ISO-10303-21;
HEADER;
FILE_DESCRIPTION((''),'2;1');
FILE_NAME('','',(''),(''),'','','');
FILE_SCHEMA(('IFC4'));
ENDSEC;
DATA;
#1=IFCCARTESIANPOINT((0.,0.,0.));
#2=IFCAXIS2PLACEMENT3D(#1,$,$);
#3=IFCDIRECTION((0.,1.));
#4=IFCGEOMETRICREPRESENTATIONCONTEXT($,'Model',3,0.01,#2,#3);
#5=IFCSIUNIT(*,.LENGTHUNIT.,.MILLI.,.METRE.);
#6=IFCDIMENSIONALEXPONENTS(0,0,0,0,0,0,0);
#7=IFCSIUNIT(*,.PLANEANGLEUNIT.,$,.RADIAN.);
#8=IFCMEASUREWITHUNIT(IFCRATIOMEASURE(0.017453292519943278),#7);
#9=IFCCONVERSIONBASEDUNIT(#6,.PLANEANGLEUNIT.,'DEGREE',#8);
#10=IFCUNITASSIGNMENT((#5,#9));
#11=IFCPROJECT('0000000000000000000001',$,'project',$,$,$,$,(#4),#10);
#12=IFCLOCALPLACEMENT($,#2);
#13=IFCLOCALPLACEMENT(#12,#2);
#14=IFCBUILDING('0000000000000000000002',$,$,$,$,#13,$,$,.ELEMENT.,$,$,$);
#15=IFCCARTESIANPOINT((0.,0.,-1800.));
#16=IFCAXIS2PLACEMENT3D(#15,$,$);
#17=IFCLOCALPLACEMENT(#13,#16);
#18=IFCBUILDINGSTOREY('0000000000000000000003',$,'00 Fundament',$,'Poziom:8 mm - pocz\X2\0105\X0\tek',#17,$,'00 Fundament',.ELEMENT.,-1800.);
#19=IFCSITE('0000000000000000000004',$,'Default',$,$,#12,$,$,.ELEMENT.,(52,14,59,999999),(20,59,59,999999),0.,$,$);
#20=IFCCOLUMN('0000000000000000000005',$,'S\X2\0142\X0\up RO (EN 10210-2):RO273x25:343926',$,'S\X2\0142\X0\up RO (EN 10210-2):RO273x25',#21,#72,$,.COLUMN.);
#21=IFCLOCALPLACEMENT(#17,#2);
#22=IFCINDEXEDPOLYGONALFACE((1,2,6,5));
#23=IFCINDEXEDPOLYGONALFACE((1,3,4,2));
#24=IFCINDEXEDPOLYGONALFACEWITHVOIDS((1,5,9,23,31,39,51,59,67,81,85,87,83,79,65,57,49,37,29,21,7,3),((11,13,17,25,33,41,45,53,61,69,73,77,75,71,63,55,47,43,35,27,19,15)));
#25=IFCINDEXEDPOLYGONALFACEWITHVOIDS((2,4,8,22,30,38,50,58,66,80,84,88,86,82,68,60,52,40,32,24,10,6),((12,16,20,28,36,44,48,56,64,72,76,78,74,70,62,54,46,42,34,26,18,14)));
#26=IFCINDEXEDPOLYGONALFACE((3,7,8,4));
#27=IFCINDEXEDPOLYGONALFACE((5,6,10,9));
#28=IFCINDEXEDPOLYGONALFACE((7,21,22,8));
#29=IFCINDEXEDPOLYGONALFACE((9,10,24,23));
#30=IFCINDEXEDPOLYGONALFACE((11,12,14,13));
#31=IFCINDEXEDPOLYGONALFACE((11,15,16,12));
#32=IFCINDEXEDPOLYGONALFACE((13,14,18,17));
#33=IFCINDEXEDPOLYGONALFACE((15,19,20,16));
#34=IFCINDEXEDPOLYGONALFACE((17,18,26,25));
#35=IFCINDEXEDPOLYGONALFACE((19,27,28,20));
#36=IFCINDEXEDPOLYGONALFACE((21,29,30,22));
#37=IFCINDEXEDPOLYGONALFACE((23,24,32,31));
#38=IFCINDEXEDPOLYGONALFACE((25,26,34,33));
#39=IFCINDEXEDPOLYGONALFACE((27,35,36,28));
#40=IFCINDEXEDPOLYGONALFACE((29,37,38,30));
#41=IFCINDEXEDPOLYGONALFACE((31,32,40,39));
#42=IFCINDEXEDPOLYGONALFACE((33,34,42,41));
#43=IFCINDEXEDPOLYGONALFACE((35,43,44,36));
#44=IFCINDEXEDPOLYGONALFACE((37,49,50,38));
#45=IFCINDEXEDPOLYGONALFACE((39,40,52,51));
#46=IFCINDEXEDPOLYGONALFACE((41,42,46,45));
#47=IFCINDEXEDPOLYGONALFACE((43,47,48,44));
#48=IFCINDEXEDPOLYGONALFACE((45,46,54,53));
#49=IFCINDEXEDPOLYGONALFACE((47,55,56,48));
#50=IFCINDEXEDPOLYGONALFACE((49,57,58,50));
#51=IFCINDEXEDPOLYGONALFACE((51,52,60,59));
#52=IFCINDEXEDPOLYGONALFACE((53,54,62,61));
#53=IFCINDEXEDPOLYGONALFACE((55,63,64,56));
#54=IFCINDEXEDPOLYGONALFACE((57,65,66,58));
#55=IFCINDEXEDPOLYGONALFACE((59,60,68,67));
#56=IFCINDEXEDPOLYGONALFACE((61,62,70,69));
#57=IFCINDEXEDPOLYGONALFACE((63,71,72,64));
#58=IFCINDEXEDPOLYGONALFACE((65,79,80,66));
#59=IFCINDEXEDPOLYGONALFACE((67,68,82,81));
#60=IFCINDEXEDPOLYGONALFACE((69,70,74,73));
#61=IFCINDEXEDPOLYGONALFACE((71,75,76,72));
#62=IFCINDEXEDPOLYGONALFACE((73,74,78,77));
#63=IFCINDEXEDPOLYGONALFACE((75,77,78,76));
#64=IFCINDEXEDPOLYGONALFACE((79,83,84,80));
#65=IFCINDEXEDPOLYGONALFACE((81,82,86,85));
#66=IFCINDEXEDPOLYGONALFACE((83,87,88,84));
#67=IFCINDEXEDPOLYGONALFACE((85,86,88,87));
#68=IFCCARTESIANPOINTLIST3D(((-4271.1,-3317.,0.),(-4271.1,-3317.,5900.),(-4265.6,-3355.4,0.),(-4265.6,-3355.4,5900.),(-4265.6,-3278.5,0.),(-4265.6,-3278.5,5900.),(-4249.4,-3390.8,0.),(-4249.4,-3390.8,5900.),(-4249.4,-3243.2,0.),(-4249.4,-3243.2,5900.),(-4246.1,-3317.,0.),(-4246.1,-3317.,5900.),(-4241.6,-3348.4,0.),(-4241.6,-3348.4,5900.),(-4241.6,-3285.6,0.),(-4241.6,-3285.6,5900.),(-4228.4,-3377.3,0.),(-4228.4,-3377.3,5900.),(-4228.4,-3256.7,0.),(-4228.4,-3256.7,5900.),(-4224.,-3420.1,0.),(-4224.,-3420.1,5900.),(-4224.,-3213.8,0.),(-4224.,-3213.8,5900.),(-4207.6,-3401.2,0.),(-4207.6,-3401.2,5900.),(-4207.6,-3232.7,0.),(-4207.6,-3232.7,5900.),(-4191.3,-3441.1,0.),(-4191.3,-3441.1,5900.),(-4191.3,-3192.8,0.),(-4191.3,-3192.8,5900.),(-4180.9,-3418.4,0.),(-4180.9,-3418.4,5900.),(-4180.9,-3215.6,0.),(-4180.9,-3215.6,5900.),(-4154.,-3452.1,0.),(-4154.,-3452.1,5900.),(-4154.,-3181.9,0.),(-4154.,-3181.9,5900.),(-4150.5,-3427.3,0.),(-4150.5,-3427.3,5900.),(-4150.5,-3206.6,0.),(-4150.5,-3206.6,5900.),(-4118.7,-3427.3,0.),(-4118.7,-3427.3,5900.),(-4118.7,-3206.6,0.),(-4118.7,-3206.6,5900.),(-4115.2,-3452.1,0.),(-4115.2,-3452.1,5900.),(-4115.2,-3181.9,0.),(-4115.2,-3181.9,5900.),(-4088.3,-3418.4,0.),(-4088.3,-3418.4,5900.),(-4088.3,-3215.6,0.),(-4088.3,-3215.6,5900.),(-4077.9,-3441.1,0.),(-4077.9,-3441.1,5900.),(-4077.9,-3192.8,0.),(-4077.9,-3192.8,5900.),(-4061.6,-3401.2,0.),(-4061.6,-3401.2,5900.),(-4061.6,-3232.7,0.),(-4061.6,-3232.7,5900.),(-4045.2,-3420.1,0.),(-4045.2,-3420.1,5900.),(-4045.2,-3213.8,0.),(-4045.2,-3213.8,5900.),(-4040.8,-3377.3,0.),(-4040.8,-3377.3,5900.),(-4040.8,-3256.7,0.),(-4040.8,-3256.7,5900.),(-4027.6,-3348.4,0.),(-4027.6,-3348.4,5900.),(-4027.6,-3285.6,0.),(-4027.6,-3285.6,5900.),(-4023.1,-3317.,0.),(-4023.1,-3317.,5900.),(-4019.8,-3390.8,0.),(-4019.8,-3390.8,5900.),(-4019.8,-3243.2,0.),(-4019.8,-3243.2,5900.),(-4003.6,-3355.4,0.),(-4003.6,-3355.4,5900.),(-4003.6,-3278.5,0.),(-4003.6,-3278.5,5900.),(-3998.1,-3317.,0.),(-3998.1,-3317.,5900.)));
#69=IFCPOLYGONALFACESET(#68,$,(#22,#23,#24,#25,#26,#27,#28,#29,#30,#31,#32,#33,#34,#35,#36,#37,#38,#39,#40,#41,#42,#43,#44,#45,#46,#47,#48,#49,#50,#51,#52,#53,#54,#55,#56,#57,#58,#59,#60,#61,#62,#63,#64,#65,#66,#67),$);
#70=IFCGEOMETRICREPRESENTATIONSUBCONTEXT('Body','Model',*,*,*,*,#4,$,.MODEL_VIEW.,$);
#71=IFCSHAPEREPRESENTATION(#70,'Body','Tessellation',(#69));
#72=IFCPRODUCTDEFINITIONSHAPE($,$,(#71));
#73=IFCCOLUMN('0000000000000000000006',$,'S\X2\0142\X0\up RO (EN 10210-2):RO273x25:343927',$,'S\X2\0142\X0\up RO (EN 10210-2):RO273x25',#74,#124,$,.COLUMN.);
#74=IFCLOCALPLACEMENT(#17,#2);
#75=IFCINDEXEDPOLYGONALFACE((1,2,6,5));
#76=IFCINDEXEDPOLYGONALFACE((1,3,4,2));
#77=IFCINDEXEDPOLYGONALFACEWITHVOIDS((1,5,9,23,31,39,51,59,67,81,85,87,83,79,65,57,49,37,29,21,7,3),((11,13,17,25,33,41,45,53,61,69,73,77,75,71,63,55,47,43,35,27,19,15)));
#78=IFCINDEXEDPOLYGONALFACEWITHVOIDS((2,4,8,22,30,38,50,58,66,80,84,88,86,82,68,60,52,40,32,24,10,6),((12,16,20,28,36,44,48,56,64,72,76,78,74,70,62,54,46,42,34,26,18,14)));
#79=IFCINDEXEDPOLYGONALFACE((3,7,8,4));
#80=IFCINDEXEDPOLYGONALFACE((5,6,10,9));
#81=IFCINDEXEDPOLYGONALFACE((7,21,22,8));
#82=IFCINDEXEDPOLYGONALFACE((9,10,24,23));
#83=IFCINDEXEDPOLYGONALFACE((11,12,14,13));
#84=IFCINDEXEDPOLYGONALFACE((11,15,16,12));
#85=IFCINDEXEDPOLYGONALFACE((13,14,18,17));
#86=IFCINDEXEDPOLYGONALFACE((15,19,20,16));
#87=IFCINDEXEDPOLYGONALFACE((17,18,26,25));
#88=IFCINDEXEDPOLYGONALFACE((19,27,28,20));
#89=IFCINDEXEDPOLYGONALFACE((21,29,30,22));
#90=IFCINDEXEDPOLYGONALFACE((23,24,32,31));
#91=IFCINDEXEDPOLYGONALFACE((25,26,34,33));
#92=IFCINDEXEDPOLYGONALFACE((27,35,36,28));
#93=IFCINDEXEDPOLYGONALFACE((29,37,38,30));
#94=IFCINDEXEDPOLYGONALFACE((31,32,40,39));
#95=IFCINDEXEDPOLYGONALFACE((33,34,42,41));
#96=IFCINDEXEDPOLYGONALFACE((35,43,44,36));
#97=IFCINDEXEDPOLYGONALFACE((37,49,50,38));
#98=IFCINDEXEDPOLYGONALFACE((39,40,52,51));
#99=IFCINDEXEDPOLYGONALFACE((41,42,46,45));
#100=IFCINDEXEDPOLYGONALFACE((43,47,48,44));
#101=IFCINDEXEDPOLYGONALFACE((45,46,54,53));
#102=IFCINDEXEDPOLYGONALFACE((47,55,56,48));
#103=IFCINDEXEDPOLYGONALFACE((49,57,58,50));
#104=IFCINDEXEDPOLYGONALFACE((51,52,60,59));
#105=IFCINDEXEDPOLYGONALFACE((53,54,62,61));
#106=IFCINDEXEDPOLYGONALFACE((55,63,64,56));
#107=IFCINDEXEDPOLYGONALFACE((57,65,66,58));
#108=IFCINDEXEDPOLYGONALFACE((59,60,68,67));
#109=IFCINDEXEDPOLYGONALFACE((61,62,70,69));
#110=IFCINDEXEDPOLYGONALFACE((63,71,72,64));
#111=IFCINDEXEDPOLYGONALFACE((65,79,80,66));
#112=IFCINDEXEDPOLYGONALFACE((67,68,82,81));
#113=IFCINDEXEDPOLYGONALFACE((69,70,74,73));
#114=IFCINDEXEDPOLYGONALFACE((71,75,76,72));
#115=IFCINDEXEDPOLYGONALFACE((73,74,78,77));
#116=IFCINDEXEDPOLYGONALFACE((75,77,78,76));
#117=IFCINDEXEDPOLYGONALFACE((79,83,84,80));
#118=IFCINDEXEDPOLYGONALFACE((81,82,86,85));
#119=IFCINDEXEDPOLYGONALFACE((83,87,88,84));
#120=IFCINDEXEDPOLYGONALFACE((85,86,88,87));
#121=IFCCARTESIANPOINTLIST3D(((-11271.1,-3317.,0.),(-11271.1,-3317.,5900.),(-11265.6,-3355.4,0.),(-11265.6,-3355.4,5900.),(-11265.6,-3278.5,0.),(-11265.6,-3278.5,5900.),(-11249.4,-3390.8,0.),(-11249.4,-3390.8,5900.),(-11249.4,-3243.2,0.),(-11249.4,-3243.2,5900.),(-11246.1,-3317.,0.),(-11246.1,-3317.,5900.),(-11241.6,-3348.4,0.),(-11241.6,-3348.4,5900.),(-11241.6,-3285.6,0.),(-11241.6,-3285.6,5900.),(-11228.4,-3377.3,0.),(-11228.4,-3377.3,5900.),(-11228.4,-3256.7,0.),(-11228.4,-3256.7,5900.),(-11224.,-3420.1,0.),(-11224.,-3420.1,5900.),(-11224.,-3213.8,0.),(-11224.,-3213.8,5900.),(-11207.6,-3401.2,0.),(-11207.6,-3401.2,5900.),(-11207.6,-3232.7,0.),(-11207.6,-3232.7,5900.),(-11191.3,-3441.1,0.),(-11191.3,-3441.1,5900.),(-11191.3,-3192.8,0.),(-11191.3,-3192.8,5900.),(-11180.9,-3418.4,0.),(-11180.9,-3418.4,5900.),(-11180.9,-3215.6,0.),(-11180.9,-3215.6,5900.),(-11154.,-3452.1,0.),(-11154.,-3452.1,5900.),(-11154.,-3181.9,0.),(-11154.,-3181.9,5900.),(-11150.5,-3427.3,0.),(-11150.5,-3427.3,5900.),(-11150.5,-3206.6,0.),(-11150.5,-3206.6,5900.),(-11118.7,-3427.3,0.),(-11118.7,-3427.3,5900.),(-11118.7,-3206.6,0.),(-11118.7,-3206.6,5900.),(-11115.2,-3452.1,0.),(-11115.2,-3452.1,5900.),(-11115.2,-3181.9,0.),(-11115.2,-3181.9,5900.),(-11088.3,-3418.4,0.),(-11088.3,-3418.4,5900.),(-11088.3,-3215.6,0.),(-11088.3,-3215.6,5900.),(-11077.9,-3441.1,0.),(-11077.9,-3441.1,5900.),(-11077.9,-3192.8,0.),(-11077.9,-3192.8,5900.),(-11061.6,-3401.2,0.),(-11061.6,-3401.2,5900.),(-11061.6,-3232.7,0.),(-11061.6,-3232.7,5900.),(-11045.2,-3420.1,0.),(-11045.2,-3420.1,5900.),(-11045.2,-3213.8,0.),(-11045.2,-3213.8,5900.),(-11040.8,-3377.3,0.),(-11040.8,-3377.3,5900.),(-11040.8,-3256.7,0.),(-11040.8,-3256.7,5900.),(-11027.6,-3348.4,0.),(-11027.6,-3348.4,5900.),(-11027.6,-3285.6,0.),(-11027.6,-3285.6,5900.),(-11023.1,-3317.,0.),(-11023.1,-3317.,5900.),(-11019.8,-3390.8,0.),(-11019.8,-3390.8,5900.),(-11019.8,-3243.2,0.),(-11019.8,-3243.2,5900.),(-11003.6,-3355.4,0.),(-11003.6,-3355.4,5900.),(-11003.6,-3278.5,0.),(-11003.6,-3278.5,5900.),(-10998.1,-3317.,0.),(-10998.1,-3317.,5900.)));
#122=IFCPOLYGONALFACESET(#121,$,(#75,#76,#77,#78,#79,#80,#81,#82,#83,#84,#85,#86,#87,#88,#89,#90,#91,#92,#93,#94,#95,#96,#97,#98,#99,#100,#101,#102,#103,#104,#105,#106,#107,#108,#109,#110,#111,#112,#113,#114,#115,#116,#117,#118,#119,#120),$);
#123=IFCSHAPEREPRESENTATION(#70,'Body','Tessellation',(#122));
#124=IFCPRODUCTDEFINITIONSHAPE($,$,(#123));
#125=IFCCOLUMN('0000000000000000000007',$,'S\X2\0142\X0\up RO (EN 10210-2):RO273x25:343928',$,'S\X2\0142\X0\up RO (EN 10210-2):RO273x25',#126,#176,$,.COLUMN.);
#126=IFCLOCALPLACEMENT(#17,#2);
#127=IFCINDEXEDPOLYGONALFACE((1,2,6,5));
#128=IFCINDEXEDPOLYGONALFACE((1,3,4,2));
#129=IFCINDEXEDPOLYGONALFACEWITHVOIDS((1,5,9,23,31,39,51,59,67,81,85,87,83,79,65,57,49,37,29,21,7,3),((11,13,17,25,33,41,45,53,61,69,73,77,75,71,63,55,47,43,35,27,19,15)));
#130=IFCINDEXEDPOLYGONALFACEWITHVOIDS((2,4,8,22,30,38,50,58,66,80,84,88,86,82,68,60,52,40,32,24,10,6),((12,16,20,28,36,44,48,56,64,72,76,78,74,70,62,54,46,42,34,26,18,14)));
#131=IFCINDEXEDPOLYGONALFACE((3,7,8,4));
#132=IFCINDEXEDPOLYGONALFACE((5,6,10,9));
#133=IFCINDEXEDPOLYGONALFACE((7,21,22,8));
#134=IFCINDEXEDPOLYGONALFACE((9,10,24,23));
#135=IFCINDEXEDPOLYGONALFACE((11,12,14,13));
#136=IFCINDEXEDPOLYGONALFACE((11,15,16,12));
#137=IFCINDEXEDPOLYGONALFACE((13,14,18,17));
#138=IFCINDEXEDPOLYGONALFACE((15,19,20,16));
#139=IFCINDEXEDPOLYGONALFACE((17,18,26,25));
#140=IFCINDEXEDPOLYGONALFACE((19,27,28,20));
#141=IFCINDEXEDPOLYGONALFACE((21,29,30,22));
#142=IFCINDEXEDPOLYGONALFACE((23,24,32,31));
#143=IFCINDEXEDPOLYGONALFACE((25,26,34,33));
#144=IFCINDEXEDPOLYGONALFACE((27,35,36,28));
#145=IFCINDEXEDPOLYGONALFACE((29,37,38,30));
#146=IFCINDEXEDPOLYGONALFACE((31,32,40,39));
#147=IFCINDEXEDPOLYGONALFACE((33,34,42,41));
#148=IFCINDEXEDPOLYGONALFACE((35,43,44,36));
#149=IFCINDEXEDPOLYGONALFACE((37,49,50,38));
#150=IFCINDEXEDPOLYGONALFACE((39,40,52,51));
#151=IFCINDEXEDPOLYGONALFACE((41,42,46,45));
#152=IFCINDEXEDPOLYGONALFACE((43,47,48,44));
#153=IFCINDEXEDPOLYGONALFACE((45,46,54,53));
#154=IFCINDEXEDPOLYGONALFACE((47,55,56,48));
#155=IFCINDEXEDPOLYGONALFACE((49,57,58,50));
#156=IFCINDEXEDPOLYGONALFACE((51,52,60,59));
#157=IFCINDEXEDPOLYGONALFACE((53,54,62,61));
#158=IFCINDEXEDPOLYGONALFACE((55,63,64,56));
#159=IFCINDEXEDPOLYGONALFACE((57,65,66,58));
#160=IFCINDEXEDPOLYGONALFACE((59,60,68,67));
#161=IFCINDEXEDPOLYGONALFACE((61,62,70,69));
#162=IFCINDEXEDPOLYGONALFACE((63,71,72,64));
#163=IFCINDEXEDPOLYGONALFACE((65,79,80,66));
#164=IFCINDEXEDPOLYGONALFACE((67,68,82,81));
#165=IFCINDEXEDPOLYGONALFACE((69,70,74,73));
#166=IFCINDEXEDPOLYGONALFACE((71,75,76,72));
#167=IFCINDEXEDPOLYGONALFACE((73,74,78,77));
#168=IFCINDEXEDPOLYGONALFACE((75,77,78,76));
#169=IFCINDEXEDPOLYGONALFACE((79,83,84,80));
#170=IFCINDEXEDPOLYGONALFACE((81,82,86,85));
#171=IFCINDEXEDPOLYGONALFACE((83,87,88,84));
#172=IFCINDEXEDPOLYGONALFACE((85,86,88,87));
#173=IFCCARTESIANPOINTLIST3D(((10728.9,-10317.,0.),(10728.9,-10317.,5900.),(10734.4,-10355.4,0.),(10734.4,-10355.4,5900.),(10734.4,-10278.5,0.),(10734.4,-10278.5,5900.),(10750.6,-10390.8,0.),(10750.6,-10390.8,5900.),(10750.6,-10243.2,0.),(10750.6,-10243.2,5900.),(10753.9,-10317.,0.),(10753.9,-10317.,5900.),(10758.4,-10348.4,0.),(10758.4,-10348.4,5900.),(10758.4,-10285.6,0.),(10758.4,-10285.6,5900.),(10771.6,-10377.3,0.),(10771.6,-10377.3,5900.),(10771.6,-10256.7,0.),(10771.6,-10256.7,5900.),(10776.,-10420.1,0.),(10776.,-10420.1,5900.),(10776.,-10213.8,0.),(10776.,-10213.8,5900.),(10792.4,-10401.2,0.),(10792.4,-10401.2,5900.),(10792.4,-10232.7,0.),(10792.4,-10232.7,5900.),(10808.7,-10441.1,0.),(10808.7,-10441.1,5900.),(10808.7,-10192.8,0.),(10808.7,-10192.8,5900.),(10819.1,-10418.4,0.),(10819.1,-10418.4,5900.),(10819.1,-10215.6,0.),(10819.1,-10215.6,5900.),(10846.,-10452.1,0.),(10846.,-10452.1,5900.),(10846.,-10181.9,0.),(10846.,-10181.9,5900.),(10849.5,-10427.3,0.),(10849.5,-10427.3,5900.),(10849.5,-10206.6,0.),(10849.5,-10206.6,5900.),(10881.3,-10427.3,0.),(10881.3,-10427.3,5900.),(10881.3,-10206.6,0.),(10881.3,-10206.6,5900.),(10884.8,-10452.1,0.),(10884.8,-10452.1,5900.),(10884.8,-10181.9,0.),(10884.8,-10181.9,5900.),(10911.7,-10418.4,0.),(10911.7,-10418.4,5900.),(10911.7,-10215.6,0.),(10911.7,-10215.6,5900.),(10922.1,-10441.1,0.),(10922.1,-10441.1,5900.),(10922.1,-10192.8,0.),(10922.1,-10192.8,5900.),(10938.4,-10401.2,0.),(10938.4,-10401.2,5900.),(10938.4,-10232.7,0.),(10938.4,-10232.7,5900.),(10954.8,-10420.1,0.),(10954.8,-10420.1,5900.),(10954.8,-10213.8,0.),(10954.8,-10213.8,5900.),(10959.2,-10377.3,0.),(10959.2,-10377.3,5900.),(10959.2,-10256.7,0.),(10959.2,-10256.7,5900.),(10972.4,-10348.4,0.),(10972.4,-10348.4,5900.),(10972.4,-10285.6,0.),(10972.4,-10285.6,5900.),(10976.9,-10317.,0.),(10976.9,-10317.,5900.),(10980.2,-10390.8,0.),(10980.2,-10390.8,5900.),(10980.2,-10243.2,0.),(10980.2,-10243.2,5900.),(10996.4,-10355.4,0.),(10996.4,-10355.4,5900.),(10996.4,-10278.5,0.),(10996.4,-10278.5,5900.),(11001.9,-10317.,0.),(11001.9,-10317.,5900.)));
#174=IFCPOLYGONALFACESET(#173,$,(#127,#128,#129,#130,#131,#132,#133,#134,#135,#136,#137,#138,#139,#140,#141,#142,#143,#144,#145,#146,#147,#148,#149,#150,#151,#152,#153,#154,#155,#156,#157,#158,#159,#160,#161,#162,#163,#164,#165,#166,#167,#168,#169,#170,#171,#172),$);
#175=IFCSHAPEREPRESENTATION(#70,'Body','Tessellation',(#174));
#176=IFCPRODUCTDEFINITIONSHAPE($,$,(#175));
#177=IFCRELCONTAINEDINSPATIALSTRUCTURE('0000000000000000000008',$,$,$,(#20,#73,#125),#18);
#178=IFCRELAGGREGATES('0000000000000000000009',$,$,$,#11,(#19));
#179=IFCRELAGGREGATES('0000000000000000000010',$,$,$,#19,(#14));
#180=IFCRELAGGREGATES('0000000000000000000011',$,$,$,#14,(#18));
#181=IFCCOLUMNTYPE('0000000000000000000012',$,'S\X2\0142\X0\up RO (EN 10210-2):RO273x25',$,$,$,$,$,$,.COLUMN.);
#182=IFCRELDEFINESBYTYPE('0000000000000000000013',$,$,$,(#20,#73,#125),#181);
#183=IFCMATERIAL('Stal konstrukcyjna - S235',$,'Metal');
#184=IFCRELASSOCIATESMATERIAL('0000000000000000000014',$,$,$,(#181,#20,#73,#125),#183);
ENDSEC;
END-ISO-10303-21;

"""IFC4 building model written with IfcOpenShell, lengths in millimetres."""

from ifc_helpers import new_model, entity, si_unit, converted_unit, direction, frame, origin, place, context, subcontext, project, spatial, arc, indexed_curve, outline, extrude, source, transform, mapped, material, type_object, type_shapes, element, save


model = new_model("IFC4")

# Units and contexts
model_context = context("Model", 3, precision=0.01, world=origin(), true_north=direction((0.0, 1.0)))
body_context = subcontext(model_context, "Body", "Model", "MODEL_VIEW")
ifc_project = project(units=[si_unit("LENGTHUNIT", "METRE", prefix="MILLI"), converted_unit("PLANEANGLEUNIT", "DEGREE", entity("IfcRatioMeasure", 0.017453292519943278), si_unit("PLANEANGLEUNIT", "RADIAN"), dimensions=[0, 0, 0, 0, 0, 0, 0])], contexts=[model_context])

# Site, building, storey
site_placement = place(None, origin())
site = spatial("IfcSite", under=ifc_project, at=site_placement, Name="Default", CompositionType="ELEMENT", RefLatitude=(52, 14, 59, 999999), RefLongitude=(20, 59, 59, 999999), RefElevation=0.0)
building_placement = place(site_placement, origin())
building = spatial("IfcBuilding", under=site, at=building_placement, CompositionType="ELEMENT")
storey_placement = place(building_placement, frame((0.0, 0.0, -1800.0)))
storey = spatial("IfcBuildingStorey", under=building, at=storey_placement, Name="00 Fundament", ObjectType="Poziom:8 mm - początek", LongName="00 Fundament", CompositionType="ELEMENT", Elevation=-1800.0)

# Columns
ifc_material_1 = material(Name="Stal konstrukcyjna - S235", Category="Metal")
column_type = type_object("IfcColumnType", Name="Słup RO (EN 10210-2):RO273x25", PredefinedType="COLUMN", material=ifc_material_1)
shared_shape = source(origin(), body_context, "Body", "SweptSolid", [
    extrude(outline(indexed_curve([(-136.5, 0.0), (0.0, -136.5), (136.5, 0.0), (0.0, 136.5)], segments=[arc(1, 2, 3), arc(3, 4, 1)], self_intersect=False), holes=[indexed_curve([(-111.5, 0.0), (0.0, 111.5), (111.5, 0.0), (0.0, -111.5)], segments=[arc(1, 2, 3), arc(3, 4, 1)], self_intersect=False)]), frame((0.0, 0.0, -1800.0)), (0.0, 0.0, 1.0), 5900.0),
])
type_shapes(column_type, [shared_shape])
for number, where, name in (
    (1, (-4134.6, -3317.0, 1800.0), "Słup RO (EN 10210-2):RO273x25:343926"),
    (2, (-11134.6, -3317.0, 1800.0), "Słup RO (EN 10210-2):RO273x25:343927"),
    (3, (10865.4, -10317.0, 1800.0), "Słup RO (EN 10210-2):RO273x25:343928"),
):
    element("IfcColumn", number, at=place(storey_placement, frame(where)), inside=storey, type_object=column_type, material=ifc_material_1, Name=name, ObjectType="Słup RO (EN 10210-2):RO273x25", PredefinedType="COLUMN", context=body_context, shape_type="MappedRepresentation", body=[
        mapped(shared_shape, transform((0.0, 0.0, 0.0), scale=1.0)),
    ])

save(model, "model.ifc")
